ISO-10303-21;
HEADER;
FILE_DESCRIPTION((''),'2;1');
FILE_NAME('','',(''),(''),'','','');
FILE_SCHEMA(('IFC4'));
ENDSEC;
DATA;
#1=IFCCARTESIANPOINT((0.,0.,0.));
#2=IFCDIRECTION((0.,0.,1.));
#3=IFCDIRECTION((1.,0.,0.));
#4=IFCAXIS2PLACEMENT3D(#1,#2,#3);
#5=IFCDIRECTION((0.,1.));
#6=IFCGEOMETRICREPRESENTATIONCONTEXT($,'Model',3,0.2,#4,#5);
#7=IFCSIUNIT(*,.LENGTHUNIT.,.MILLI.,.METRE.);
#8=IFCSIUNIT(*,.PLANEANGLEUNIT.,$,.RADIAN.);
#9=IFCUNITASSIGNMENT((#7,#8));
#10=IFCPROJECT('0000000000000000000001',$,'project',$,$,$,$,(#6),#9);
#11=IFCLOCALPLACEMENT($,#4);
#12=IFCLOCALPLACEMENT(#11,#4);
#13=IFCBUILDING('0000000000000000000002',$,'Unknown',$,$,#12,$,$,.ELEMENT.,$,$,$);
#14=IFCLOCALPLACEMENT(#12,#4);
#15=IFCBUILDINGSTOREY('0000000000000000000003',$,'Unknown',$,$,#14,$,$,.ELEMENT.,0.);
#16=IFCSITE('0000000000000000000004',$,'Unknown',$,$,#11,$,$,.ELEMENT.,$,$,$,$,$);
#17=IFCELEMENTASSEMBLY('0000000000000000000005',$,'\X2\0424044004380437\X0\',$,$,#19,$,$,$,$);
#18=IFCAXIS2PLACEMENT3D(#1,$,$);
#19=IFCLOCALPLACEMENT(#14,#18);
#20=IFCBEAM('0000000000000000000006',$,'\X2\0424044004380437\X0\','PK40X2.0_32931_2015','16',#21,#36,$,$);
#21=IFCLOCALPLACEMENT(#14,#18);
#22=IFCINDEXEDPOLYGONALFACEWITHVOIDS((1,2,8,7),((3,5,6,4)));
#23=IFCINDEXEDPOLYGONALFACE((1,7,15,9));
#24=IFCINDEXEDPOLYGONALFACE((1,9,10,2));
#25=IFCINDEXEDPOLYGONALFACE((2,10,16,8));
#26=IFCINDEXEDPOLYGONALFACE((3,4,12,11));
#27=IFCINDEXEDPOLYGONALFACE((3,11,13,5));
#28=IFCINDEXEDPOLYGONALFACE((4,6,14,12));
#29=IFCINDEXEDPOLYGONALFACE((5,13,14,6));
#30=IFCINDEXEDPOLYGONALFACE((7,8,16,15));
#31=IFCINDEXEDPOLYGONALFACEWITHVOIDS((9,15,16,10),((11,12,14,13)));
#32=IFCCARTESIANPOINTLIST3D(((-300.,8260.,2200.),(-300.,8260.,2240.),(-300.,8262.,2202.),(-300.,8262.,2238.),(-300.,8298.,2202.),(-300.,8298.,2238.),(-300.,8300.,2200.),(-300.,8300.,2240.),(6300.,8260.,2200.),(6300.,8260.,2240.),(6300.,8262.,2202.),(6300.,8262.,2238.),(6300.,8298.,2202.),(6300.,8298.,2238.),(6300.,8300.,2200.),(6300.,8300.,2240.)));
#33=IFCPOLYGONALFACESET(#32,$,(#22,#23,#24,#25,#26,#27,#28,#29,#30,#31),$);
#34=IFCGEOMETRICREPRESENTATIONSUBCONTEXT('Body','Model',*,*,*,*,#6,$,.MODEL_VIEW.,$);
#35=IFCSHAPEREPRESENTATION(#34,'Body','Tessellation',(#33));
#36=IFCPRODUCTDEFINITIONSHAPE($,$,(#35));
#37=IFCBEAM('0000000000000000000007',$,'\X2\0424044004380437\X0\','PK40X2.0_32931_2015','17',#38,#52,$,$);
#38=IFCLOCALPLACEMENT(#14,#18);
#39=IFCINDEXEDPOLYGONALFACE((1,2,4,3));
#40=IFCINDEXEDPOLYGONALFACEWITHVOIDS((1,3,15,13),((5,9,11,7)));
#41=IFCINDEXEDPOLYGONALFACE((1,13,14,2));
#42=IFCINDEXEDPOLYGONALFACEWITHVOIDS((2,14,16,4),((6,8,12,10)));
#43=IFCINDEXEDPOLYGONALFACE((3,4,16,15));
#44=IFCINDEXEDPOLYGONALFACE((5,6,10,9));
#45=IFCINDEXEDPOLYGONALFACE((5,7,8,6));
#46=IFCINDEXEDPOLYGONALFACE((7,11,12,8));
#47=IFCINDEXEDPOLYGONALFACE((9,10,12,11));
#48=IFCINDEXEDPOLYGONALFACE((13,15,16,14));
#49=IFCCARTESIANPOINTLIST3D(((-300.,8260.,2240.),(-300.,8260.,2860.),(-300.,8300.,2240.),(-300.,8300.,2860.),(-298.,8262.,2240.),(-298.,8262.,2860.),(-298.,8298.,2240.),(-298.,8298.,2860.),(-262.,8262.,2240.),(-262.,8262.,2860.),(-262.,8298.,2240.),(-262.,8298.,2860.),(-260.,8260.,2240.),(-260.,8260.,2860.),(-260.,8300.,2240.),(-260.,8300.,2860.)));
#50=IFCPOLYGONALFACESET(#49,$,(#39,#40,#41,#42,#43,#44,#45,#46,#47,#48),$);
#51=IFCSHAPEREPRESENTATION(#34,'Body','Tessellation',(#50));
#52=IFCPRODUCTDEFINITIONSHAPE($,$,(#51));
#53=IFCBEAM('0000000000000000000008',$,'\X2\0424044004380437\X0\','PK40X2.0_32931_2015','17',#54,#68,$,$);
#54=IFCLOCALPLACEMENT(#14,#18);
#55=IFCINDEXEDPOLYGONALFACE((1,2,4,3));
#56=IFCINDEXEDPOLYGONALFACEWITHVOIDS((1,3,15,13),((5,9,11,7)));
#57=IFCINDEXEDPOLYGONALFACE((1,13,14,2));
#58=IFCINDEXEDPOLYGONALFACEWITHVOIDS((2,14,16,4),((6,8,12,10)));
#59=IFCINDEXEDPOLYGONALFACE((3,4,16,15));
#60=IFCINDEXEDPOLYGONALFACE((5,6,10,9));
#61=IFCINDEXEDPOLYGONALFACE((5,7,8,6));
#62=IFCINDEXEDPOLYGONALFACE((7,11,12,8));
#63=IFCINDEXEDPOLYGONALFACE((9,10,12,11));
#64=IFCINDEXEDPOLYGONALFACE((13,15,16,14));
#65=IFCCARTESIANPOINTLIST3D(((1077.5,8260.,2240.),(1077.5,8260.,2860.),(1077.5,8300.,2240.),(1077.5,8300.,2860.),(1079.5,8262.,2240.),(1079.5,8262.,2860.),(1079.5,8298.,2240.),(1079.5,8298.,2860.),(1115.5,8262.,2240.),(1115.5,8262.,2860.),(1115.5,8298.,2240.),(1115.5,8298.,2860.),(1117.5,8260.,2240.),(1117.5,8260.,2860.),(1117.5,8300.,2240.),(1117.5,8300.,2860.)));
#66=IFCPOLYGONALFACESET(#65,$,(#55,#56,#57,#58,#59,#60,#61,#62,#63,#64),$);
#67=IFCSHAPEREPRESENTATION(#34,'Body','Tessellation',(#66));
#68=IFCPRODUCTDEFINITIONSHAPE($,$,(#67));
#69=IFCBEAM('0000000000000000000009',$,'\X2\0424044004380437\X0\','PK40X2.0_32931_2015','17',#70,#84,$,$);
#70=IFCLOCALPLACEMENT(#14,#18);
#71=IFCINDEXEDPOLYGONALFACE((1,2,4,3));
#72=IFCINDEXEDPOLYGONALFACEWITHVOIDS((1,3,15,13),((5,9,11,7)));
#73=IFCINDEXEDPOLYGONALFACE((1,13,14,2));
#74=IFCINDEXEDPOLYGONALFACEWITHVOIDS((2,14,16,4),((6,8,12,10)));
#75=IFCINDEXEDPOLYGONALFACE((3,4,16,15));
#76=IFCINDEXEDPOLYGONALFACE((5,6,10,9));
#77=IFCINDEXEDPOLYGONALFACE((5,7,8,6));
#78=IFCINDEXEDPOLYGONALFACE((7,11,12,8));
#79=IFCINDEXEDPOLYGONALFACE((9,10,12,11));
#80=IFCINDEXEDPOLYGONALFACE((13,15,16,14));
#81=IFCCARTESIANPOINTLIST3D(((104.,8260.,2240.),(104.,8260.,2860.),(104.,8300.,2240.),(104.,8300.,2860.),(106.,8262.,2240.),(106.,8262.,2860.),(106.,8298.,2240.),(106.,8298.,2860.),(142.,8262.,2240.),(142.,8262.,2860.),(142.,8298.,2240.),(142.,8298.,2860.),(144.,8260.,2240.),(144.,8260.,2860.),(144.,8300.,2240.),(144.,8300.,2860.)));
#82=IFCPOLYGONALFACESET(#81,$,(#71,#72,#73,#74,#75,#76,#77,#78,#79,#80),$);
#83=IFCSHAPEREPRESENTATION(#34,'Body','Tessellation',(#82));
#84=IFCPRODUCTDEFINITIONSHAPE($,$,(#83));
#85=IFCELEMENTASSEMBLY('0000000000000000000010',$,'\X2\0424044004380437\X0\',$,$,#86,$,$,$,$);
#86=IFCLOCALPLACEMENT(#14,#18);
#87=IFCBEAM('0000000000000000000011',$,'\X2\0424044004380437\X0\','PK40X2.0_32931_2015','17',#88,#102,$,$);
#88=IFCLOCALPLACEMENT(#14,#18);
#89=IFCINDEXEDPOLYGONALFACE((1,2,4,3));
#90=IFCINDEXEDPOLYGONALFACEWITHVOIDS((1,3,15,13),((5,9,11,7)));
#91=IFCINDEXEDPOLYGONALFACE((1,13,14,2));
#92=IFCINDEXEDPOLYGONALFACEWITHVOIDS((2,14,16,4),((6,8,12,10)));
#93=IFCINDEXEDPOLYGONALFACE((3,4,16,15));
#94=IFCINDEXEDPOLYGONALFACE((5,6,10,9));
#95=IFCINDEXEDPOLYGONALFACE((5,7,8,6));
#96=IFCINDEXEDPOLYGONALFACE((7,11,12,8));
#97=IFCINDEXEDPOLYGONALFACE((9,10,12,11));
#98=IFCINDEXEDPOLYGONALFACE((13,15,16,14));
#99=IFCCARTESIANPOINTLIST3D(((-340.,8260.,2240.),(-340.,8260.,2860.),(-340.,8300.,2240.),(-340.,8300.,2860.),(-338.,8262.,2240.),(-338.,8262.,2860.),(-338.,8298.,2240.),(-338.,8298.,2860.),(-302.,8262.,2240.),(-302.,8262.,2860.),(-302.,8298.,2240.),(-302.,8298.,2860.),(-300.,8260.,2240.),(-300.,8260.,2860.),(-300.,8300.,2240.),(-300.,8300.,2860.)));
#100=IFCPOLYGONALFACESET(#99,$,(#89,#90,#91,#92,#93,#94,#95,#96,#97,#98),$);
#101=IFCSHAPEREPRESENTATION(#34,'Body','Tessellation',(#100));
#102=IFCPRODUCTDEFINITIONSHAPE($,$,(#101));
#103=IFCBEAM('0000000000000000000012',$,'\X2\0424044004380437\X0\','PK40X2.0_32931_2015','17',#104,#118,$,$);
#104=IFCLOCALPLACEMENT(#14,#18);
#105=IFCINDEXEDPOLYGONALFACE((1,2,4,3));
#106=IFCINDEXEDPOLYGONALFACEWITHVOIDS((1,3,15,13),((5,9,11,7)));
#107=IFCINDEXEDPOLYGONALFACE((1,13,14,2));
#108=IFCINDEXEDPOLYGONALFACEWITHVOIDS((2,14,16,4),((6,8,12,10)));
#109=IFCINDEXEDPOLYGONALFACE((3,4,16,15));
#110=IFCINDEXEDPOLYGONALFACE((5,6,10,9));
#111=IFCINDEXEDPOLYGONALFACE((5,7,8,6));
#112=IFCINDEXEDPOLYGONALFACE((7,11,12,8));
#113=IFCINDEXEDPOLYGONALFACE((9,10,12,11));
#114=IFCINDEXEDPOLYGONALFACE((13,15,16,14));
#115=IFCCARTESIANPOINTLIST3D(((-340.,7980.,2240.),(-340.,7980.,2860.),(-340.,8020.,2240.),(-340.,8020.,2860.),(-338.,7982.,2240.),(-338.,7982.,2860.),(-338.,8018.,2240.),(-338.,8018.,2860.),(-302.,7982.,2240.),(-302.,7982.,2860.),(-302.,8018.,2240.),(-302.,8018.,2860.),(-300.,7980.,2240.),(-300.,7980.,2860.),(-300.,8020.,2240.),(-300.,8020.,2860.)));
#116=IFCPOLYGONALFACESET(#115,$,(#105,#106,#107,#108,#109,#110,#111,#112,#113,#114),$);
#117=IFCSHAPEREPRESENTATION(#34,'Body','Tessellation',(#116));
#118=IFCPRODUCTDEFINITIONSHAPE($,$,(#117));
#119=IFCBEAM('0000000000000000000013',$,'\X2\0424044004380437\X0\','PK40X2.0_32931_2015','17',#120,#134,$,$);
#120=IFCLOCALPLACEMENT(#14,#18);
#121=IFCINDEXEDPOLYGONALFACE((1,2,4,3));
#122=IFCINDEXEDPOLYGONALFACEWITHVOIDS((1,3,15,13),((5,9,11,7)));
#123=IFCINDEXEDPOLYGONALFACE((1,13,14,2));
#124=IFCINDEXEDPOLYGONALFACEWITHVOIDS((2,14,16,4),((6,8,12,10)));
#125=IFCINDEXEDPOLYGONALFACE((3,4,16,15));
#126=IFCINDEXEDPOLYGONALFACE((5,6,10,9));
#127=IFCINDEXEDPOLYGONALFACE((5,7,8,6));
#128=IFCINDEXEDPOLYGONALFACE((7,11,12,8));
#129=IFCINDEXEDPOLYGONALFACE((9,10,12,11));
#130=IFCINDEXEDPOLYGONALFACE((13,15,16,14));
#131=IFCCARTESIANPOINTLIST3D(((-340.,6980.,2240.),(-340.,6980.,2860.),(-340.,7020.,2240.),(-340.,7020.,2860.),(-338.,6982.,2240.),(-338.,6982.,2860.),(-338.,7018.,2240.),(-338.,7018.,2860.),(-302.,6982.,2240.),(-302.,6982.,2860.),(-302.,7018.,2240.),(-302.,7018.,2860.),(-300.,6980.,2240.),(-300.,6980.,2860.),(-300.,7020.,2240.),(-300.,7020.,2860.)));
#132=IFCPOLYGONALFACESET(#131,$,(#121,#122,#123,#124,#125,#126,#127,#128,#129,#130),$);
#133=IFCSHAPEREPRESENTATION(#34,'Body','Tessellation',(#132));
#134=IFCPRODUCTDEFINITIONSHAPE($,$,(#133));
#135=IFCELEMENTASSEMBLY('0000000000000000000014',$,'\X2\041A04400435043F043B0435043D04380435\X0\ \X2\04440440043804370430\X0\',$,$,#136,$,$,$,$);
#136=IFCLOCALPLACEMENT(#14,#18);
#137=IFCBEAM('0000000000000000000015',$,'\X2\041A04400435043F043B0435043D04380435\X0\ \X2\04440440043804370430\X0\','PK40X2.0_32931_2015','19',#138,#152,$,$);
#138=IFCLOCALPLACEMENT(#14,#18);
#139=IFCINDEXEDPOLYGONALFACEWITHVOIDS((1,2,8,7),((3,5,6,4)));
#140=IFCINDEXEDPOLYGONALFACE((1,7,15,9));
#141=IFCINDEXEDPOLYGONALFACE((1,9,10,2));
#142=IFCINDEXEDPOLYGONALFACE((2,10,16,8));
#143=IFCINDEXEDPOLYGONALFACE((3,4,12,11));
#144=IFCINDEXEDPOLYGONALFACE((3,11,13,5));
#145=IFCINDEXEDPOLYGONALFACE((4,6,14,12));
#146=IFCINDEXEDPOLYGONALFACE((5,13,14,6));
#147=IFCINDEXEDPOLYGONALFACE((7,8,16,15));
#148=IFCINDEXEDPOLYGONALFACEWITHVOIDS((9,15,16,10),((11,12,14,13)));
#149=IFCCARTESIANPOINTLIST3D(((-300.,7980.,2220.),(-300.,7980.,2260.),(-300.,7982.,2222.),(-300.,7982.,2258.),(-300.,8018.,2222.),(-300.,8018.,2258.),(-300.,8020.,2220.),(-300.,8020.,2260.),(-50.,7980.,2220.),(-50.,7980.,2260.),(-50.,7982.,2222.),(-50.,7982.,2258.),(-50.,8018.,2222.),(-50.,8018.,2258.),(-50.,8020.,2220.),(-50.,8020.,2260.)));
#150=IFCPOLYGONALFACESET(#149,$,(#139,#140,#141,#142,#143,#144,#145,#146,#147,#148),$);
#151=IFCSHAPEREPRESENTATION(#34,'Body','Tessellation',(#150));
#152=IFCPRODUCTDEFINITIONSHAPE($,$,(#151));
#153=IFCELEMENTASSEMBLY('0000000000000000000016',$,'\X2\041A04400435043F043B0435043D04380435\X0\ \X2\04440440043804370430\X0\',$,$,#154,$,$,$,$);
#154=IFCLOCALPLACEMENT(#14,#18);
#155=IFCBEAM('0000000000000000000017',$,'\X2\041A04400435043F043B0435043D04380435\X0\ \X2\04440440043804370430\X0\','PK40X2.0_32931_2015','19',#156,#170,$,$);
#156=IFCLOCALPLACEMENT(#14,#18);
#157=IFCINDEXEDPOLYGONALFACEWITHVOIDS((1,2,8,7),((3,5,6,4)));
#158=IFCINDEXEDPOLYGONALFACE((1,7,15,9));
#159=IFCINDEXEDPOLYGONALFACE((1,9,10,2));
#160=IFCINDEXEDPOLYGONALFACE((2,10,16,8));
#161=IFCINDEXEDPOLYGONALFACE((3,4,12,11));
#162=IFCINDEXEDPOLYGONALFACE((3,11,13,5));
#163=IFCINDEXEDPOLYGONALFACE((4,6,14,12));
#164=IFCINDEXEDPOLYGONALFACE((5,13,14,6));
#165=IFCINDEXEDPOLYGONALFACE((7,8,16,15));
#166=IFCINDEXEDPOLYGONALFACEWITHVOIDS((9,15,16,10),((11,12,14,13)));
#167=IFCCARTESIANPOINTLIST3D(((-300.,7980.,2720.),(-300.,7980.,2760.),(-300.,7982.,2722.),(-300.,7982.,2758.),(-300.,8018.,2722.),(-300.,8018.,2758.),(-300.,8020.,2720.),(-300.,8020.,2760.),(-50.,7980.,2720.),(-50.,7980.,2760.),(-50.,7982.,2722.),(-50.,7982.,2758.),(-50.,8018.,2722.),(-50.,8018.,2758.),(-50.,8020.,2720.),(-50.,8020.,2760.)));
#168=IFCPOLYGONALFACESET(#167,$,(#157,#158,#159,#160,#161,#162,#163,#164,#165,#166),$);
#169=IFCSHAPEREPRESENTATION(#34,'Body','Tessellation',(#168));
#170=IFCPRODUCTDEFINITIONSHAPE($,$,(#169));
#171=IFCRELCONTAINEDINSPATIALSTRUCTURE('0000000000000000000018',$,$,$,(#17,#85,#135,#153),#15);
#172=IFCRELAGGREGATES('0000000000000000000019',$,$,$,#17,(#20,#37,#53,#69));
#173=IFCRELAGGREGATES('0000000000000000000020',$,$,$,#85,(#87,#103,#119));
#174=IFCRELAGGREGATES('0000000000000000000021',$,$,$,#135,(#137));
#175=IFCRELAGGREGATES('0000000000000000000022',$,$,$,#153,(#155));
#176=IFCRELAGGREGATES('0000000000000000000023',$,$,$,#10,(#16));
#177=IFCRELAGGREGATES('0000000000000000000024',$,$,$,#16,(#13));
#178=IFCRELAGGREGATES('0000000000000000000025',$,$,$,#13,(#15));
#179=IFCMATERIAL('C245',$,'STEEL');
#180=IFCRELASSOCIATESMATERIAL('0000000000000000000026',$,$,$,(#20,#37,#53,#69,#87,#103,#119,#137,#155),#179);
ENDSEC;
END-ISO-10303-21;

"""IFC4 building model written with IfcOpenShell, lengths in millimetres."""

from ifc_helpers import new_model, si_unit, direction, frame, origin_with_axes, place, context, subcontext, project, spatial, line, indexed_curve, outline, extrude, material, element, aggregate, save


model = new_model("IFC4")

# Units and contexts
model_context = context("Model", 3, precision=0.2, world=origin_with_axes(), true_north=direction((0.0, 1.0)))
body_context = subcontext(model_context, "Body", "Model", "MODEL_VIEW")
ifc_project = project(units=[si_unit("LENGTHUNIT", "METRE", prefix="MILLI"), si_unit("PLANEANGLEUNIT", "RADIAN")], contexts=[model_context])

# Site, building, storey
site_placement = place(None, origin_with_axes())
site = spatial("IfcSite", under=ifc_project, at=site_placement, Name="Unknown", CompositionType="ELEMENT")
building_placement = place(site_placement, origin_with_axes())
building = spatial("IfcBuilding", under=site, at=building_placement, Name="Unknown", CompositionType="ELEMENT")
storey_placement = place(building_placement, origin_with_axes())
storey = spatial("IfcBuildingStorey", under=building, at=storey_placement, Name="Unknown", CompositionType="ELEMENT", Elevation=0.0)

# Shared definitions
ifc_material_1 = material(Name="C245", Category="STEEL")

# Element assembly, beams
assembly_1_placement = place(storey_placement, frame((-300.0, 8280.0, 2880.0), z_axis=(0.0, -1.0, 0.0), x_axis=(1.0, 0.0, 0.0)))
assembly_1 = element("IfcElementAssembly", 1, at=assembly_1_placement, inside=storey, Name="Фриз")
beam_1_placement = place(assembly_1_placement, frame((0.0, -660.0, 0.0), z_axis=(0.0, 0.0, 1.0), x_axis=(1.0, 0.0, 0.0)))
beam_1 = element("IfcBeam", 2, at=beam_1_placement, material=ifc_material_1, Name="Фриз", Description="PK40X2.0_32931_2015", ObjectType="16", context=body_context, shape_type="SolidModel", body=[
    extrude(outline(indexed_curve([(-20.0, -20.0), (20.0, -20.0), (20.0, 20.0), (-20.0, 20.0)], segments=[line(1, 2, 3, 4, 1)]), holes=[indexed_curve([(-18.0, -18.0), (-18.0, 18.0), (18.0, 18.0), (18.0, -18.0)], segments=[line(1, 2, 3, 4, 1)])]), frame((0.0, 0.0, 0.0), z_axis=(-1.0, 0.0, 0.0), x_axis=(0.0, 0.0, 1.0)), (0.0, 0.0, -1.0), 6600.0),
])
beam_2_placement = place(assembly_1_placement, frame((20.0, -20.0, 0.0), z_axis=(0.0, 0.0, -1.0), x_axis=(0.0, -1.0, 0.0)))
beam_2 = element("IfcBeam", 3, at=beam_2_placement, material=ifc_material_1, Name="Фриз", Description="PK40X2.0_32931_2015", ObjectType="17", context=body_context, shape_type="SolidModel", body=[
    extrude(outline(indexed_curve([(-20.0, -20.0), (20.0, -20.0), (20.0, 20.0), (-20.0, 20.0)], segments=[line(1, 2, 3, 4, 1)]), holes=[indexed_curve([(-18.0, -18.0), (-18.0, 18.0), (18.0, 18.0), (18.0, -18.0)], segments=[line(1, 2, 3, 4, 1)])]), frame((0.0, 0.0, 0.0), z_axis=(-1.0, 0.0, 0.0), x_axis=(0.0, 0.0, 1.0)), (0.0, 0.0, -1.0), 620.0),
])
beam_3_placement = place(assembly_1_placement, frame((1397.5, -20.0, 0.0), z_axis=(0.0, 0.0, 1.0), x_axis=(0.0, -1.0, 0.0)))
beam_3 = element("IfcBeam", 4, at=beam_3_placement, material=ifc_material_1, Name="Фриз", Description="PK40X2.0_32931_2015", ObjectType="17", context=body_context, shape_type="SolidModel", body=[
    extrude(outline(indexed_curve([(-20.0, -20.0), (20.0, -20.0), (20.0, 20.0), (-20.0, 20.0)], segments=[line(1, 2, 3, 4, 1)]), holes=[indexed_curve([(-18.0, -18.0), (-18.0, 18.0), (18.0, 18.0), (18.0, -18.0)], segments=[line(1, 2, 3, 4, 1)])]), frame((0.0, 0.0, 0.0), z_axis=(-1.0, 0.0, 0.0), x_axis=(0.0, 0.0, 1.0)), (0.0, 0.0, -1.0), 620.0),
])
beam_4_placement = place(assembly_1_placement, frame((424.0, -20.0, 0.0), z_axis=(0.0, 0.0, 1.0), x_axis=(0.0, -1.0, 0.0)))
beam_4 = element("IfcBeam", 5, at=beam_4_placement, material=ifc_material_1, Name="Фриз", Description="PK40X2.0_32931_2015", ObjectType="17", context=body_context, shape_type="SolidModel", body=[
    extrude(outline(indexed_curve([(-20.0, -20.0), (20.0, -20.0), (20.0, 20.0), (-20.0, 20.0)], segments=[line(1, 2, 3, 4, 1)]), holes=[indexed_curve([(-18.0, -18.0), (-18.0, 18.0), (18.0, 18.0), (18.0, -18.0)], segments=[line(1, 2, 3, 4, 1)])]), frame((0.0, 0.0, 0.0), z_axis=(-1.0, 0.0, 0.0), x_axis=(0.0, 0.0, 1.0)), (0.0, 0.0, -1.0), 620.0),
])
aggregate(assembly_1, [beam_1, beam_2, beam_3, beam_4])

# Element assembly, beams
assembly_2_placement = place(storey_placement, frame((-320.0, -300.0, 2880.0), z_axis=(1.0, 0.0, 0.0), x_axis=(0.0, 1.0, 0.0)))
assembly_2 = element("IfcElementAssembly", 6, at=assembly_2_placement, inside=storey, Name="Фриз")
beam_5_placement = place(assembly_2_placement, frame((8580.0, -20.0, 0.0), z_axis=(-1.0, 0.0, 0.0), x_axis=(0.0, -1.0, 0.0)))
beam_5 = element("IfcBeam", 7, at=beam_5_placement, material=ifc_material_1, Name="Фриз", Description="PK40X2.0_32931_2015", ObjectType="17", context=body_context, shape_type="SolidModel", body=[
    extrude(outline(indexed_curve([(-20.0, -20.0), (20.0, -20.0), (20.0, 20.0), (-20.0, 20.0)], segments=[line(1, 2, 3, 4, 1)]), holes=[indexed_curve([(-18.0, -18.0), (-18.0, 18.0), (18.0, 18.0), (18.0, -18.0)], segments=[line(1, 2, 3, 4, 1)])]), frame((0.0, 0.0, 0.0), z_axis=(-1.0, 0.0, 0.0), x_axis=(0.0, 0.0, 1.0)), (0.0, 0.0, -1.0), 620.0),
])
beam_6_placement = place(assembly_2_placement, frame((8300.0, -20.0, 0.0), z_axis=(-1.0, 0.0, 0.0), x_axis=(0.0, -1.0, 0.0)))
beam_6 = element("IfcBeam", 8, at=beam_6_placement, material=ifc_material_1, Name="Фриз", Description="PK40X2.0_32931_2015", ObjectType="17", context=body_context, shape_type="SolidModel", body=[
    extrude(outline(indexed_curve([(-20.0, -20.0), (20.0, -20.0), (20.0, 20.0), (-20.0, 20.0)], segments=[line(1, 2, 3, 4, 1)]), holes=[indexed_curve([(-18.0, -18.0), (-18.0, 18.0), (18.0, 18.0), (18.0, -18.0)], segments=[line(1, 2, 3, 4, 1)])]), frame((0.0, 0.0, 0.0), z_axis=(-1.0, 0.0, 0.0), x_axis=(0.0, 0.0, 1.0)), (0.0, 0.0, -1.0), 620.0),
])
beam_7_placement = place(assembly_2_placement, frame((7300.0, -20.0, 0.0), z_axis=(-1.0, 0.0, 0.0), x_axis=(0.0, -1.0, 0.0)))
beam_7 = element("IfcBeam", 9, at=beam_7_placement, material=ifc_material_1, Name="Фриз", Description="PK40X2.0_32931_2015", ObjectType="17", context=body_context, shape_type="SolidModel", body=[
    extrude(outline(indexed_curve([(-20.0, -20.0), (20.0, -20.0), (20.0, 20.0), (-20.0, 20.0)], segments=[line(1, 2, 3, 4, 1)]), holes=[indexed_curve([(-18.0, -18.0), (-18.0, 18.0), (18.0, 18.0), (18.0, -18.0)], segments=[line(1, 2, 3, 4, 1)])]), frame((0.0, 0.0, 0.0), z_axis=(-1.0, 0.0, 0.0), x_axis=(0.0, 0.0, 1.0)), (0.0, 0.0, -1.0), 620.0),
])
aggregate(assembly_2, [beam_5, beam_6, beam_7])

# Element assemblies, beams
assembly_3_placement = place(storey_placement, frame((-300.0, 8000.0, 2240.0), z_axis=(0.0, 1.0, 0.0), x_axis=(1.0, 0.0, 0.0)))
assembly_3 = element("IfcElementAssembly", 10, at=assembly_3_placement, inside=storey, Name="Крепление фриза")
beam_8_placement = place(assembly_3_placement, origin_with_axes())
beam_8 = element("IfcBeam", 11, at=beam_8_placement, material=ifc_material_1, Name="Крепление фриза", Description="PK40X2.0_32931_2015", ObjectType="19", context=body_context, shape_type="SolidModel", body=[
    extrude(outline(indexed_curve([(-20.0, -20.0), (20.0, -20.0), (20.0, 20.0), (-20.0, 20.0)], segments=[line(1, 2, 3, 4, 1)]), holes=[indexed_curve([(-18.0, -18.0), (-18.0, 18.0), (18.0, 18.0), (18.0, -18.0)], segments=[line(1, 2, 3, 4, 1)])]), frame((0.0, 0.0, 0.0), z_axis=(-1.0, 0.0, 0.0), x_axis=(0.0, 0.0, 1.0)), (0.0, 0.0, -1.0), 250.0),
])
aggregate(assembly_3, [beam_8])
assembly_4_placement = place(storey_placement, frame((-300.0, 8000.0, 2740.0), z_axis=(0.0, 1.0, 0.0), x_axis=(1.0, 0.0, 0.0)))
assembly_4 = element("IfcElementAssembly", 12, at=assembly_4_placement, inside=storey, Name="Крепление фриза")
beam_9_placement = place(assembly_4_placement, origin_with_axes())
beam_9 = element("IfcBeam", 13, at=beam_9_placement, material=ifc_material_1, Name="Крепление фриза", Description="PK40X2.0_32931_2015", ObjectType="19", context=body_context, shape_type="SolidModel", body=[
    extrude(outline(indexed_curve([(-20.0, -20.0), (20.0, -20.0), (20.0, 20.0), (-20.0, 20.0)], segments=[line(1, 2, 3, 4, 1)]), holes=[indexed_curve([(-18.0, -18.0), (-18.0, 18.0), (18.0, 18.0), (18.0, -18.0)], segments=[line(1, 2, 3, 4, 1)])]), frame((0.0, 0.0, 0.0), z_axis=(-1.0, 0.0, 0.0), x_axis=(0.0, 0.0, 1.0)), (0.0, 0.0, -1.0), 250.0),
])
aggregate(assembly_4, [beam_9])

save(model, "model.ifc")
